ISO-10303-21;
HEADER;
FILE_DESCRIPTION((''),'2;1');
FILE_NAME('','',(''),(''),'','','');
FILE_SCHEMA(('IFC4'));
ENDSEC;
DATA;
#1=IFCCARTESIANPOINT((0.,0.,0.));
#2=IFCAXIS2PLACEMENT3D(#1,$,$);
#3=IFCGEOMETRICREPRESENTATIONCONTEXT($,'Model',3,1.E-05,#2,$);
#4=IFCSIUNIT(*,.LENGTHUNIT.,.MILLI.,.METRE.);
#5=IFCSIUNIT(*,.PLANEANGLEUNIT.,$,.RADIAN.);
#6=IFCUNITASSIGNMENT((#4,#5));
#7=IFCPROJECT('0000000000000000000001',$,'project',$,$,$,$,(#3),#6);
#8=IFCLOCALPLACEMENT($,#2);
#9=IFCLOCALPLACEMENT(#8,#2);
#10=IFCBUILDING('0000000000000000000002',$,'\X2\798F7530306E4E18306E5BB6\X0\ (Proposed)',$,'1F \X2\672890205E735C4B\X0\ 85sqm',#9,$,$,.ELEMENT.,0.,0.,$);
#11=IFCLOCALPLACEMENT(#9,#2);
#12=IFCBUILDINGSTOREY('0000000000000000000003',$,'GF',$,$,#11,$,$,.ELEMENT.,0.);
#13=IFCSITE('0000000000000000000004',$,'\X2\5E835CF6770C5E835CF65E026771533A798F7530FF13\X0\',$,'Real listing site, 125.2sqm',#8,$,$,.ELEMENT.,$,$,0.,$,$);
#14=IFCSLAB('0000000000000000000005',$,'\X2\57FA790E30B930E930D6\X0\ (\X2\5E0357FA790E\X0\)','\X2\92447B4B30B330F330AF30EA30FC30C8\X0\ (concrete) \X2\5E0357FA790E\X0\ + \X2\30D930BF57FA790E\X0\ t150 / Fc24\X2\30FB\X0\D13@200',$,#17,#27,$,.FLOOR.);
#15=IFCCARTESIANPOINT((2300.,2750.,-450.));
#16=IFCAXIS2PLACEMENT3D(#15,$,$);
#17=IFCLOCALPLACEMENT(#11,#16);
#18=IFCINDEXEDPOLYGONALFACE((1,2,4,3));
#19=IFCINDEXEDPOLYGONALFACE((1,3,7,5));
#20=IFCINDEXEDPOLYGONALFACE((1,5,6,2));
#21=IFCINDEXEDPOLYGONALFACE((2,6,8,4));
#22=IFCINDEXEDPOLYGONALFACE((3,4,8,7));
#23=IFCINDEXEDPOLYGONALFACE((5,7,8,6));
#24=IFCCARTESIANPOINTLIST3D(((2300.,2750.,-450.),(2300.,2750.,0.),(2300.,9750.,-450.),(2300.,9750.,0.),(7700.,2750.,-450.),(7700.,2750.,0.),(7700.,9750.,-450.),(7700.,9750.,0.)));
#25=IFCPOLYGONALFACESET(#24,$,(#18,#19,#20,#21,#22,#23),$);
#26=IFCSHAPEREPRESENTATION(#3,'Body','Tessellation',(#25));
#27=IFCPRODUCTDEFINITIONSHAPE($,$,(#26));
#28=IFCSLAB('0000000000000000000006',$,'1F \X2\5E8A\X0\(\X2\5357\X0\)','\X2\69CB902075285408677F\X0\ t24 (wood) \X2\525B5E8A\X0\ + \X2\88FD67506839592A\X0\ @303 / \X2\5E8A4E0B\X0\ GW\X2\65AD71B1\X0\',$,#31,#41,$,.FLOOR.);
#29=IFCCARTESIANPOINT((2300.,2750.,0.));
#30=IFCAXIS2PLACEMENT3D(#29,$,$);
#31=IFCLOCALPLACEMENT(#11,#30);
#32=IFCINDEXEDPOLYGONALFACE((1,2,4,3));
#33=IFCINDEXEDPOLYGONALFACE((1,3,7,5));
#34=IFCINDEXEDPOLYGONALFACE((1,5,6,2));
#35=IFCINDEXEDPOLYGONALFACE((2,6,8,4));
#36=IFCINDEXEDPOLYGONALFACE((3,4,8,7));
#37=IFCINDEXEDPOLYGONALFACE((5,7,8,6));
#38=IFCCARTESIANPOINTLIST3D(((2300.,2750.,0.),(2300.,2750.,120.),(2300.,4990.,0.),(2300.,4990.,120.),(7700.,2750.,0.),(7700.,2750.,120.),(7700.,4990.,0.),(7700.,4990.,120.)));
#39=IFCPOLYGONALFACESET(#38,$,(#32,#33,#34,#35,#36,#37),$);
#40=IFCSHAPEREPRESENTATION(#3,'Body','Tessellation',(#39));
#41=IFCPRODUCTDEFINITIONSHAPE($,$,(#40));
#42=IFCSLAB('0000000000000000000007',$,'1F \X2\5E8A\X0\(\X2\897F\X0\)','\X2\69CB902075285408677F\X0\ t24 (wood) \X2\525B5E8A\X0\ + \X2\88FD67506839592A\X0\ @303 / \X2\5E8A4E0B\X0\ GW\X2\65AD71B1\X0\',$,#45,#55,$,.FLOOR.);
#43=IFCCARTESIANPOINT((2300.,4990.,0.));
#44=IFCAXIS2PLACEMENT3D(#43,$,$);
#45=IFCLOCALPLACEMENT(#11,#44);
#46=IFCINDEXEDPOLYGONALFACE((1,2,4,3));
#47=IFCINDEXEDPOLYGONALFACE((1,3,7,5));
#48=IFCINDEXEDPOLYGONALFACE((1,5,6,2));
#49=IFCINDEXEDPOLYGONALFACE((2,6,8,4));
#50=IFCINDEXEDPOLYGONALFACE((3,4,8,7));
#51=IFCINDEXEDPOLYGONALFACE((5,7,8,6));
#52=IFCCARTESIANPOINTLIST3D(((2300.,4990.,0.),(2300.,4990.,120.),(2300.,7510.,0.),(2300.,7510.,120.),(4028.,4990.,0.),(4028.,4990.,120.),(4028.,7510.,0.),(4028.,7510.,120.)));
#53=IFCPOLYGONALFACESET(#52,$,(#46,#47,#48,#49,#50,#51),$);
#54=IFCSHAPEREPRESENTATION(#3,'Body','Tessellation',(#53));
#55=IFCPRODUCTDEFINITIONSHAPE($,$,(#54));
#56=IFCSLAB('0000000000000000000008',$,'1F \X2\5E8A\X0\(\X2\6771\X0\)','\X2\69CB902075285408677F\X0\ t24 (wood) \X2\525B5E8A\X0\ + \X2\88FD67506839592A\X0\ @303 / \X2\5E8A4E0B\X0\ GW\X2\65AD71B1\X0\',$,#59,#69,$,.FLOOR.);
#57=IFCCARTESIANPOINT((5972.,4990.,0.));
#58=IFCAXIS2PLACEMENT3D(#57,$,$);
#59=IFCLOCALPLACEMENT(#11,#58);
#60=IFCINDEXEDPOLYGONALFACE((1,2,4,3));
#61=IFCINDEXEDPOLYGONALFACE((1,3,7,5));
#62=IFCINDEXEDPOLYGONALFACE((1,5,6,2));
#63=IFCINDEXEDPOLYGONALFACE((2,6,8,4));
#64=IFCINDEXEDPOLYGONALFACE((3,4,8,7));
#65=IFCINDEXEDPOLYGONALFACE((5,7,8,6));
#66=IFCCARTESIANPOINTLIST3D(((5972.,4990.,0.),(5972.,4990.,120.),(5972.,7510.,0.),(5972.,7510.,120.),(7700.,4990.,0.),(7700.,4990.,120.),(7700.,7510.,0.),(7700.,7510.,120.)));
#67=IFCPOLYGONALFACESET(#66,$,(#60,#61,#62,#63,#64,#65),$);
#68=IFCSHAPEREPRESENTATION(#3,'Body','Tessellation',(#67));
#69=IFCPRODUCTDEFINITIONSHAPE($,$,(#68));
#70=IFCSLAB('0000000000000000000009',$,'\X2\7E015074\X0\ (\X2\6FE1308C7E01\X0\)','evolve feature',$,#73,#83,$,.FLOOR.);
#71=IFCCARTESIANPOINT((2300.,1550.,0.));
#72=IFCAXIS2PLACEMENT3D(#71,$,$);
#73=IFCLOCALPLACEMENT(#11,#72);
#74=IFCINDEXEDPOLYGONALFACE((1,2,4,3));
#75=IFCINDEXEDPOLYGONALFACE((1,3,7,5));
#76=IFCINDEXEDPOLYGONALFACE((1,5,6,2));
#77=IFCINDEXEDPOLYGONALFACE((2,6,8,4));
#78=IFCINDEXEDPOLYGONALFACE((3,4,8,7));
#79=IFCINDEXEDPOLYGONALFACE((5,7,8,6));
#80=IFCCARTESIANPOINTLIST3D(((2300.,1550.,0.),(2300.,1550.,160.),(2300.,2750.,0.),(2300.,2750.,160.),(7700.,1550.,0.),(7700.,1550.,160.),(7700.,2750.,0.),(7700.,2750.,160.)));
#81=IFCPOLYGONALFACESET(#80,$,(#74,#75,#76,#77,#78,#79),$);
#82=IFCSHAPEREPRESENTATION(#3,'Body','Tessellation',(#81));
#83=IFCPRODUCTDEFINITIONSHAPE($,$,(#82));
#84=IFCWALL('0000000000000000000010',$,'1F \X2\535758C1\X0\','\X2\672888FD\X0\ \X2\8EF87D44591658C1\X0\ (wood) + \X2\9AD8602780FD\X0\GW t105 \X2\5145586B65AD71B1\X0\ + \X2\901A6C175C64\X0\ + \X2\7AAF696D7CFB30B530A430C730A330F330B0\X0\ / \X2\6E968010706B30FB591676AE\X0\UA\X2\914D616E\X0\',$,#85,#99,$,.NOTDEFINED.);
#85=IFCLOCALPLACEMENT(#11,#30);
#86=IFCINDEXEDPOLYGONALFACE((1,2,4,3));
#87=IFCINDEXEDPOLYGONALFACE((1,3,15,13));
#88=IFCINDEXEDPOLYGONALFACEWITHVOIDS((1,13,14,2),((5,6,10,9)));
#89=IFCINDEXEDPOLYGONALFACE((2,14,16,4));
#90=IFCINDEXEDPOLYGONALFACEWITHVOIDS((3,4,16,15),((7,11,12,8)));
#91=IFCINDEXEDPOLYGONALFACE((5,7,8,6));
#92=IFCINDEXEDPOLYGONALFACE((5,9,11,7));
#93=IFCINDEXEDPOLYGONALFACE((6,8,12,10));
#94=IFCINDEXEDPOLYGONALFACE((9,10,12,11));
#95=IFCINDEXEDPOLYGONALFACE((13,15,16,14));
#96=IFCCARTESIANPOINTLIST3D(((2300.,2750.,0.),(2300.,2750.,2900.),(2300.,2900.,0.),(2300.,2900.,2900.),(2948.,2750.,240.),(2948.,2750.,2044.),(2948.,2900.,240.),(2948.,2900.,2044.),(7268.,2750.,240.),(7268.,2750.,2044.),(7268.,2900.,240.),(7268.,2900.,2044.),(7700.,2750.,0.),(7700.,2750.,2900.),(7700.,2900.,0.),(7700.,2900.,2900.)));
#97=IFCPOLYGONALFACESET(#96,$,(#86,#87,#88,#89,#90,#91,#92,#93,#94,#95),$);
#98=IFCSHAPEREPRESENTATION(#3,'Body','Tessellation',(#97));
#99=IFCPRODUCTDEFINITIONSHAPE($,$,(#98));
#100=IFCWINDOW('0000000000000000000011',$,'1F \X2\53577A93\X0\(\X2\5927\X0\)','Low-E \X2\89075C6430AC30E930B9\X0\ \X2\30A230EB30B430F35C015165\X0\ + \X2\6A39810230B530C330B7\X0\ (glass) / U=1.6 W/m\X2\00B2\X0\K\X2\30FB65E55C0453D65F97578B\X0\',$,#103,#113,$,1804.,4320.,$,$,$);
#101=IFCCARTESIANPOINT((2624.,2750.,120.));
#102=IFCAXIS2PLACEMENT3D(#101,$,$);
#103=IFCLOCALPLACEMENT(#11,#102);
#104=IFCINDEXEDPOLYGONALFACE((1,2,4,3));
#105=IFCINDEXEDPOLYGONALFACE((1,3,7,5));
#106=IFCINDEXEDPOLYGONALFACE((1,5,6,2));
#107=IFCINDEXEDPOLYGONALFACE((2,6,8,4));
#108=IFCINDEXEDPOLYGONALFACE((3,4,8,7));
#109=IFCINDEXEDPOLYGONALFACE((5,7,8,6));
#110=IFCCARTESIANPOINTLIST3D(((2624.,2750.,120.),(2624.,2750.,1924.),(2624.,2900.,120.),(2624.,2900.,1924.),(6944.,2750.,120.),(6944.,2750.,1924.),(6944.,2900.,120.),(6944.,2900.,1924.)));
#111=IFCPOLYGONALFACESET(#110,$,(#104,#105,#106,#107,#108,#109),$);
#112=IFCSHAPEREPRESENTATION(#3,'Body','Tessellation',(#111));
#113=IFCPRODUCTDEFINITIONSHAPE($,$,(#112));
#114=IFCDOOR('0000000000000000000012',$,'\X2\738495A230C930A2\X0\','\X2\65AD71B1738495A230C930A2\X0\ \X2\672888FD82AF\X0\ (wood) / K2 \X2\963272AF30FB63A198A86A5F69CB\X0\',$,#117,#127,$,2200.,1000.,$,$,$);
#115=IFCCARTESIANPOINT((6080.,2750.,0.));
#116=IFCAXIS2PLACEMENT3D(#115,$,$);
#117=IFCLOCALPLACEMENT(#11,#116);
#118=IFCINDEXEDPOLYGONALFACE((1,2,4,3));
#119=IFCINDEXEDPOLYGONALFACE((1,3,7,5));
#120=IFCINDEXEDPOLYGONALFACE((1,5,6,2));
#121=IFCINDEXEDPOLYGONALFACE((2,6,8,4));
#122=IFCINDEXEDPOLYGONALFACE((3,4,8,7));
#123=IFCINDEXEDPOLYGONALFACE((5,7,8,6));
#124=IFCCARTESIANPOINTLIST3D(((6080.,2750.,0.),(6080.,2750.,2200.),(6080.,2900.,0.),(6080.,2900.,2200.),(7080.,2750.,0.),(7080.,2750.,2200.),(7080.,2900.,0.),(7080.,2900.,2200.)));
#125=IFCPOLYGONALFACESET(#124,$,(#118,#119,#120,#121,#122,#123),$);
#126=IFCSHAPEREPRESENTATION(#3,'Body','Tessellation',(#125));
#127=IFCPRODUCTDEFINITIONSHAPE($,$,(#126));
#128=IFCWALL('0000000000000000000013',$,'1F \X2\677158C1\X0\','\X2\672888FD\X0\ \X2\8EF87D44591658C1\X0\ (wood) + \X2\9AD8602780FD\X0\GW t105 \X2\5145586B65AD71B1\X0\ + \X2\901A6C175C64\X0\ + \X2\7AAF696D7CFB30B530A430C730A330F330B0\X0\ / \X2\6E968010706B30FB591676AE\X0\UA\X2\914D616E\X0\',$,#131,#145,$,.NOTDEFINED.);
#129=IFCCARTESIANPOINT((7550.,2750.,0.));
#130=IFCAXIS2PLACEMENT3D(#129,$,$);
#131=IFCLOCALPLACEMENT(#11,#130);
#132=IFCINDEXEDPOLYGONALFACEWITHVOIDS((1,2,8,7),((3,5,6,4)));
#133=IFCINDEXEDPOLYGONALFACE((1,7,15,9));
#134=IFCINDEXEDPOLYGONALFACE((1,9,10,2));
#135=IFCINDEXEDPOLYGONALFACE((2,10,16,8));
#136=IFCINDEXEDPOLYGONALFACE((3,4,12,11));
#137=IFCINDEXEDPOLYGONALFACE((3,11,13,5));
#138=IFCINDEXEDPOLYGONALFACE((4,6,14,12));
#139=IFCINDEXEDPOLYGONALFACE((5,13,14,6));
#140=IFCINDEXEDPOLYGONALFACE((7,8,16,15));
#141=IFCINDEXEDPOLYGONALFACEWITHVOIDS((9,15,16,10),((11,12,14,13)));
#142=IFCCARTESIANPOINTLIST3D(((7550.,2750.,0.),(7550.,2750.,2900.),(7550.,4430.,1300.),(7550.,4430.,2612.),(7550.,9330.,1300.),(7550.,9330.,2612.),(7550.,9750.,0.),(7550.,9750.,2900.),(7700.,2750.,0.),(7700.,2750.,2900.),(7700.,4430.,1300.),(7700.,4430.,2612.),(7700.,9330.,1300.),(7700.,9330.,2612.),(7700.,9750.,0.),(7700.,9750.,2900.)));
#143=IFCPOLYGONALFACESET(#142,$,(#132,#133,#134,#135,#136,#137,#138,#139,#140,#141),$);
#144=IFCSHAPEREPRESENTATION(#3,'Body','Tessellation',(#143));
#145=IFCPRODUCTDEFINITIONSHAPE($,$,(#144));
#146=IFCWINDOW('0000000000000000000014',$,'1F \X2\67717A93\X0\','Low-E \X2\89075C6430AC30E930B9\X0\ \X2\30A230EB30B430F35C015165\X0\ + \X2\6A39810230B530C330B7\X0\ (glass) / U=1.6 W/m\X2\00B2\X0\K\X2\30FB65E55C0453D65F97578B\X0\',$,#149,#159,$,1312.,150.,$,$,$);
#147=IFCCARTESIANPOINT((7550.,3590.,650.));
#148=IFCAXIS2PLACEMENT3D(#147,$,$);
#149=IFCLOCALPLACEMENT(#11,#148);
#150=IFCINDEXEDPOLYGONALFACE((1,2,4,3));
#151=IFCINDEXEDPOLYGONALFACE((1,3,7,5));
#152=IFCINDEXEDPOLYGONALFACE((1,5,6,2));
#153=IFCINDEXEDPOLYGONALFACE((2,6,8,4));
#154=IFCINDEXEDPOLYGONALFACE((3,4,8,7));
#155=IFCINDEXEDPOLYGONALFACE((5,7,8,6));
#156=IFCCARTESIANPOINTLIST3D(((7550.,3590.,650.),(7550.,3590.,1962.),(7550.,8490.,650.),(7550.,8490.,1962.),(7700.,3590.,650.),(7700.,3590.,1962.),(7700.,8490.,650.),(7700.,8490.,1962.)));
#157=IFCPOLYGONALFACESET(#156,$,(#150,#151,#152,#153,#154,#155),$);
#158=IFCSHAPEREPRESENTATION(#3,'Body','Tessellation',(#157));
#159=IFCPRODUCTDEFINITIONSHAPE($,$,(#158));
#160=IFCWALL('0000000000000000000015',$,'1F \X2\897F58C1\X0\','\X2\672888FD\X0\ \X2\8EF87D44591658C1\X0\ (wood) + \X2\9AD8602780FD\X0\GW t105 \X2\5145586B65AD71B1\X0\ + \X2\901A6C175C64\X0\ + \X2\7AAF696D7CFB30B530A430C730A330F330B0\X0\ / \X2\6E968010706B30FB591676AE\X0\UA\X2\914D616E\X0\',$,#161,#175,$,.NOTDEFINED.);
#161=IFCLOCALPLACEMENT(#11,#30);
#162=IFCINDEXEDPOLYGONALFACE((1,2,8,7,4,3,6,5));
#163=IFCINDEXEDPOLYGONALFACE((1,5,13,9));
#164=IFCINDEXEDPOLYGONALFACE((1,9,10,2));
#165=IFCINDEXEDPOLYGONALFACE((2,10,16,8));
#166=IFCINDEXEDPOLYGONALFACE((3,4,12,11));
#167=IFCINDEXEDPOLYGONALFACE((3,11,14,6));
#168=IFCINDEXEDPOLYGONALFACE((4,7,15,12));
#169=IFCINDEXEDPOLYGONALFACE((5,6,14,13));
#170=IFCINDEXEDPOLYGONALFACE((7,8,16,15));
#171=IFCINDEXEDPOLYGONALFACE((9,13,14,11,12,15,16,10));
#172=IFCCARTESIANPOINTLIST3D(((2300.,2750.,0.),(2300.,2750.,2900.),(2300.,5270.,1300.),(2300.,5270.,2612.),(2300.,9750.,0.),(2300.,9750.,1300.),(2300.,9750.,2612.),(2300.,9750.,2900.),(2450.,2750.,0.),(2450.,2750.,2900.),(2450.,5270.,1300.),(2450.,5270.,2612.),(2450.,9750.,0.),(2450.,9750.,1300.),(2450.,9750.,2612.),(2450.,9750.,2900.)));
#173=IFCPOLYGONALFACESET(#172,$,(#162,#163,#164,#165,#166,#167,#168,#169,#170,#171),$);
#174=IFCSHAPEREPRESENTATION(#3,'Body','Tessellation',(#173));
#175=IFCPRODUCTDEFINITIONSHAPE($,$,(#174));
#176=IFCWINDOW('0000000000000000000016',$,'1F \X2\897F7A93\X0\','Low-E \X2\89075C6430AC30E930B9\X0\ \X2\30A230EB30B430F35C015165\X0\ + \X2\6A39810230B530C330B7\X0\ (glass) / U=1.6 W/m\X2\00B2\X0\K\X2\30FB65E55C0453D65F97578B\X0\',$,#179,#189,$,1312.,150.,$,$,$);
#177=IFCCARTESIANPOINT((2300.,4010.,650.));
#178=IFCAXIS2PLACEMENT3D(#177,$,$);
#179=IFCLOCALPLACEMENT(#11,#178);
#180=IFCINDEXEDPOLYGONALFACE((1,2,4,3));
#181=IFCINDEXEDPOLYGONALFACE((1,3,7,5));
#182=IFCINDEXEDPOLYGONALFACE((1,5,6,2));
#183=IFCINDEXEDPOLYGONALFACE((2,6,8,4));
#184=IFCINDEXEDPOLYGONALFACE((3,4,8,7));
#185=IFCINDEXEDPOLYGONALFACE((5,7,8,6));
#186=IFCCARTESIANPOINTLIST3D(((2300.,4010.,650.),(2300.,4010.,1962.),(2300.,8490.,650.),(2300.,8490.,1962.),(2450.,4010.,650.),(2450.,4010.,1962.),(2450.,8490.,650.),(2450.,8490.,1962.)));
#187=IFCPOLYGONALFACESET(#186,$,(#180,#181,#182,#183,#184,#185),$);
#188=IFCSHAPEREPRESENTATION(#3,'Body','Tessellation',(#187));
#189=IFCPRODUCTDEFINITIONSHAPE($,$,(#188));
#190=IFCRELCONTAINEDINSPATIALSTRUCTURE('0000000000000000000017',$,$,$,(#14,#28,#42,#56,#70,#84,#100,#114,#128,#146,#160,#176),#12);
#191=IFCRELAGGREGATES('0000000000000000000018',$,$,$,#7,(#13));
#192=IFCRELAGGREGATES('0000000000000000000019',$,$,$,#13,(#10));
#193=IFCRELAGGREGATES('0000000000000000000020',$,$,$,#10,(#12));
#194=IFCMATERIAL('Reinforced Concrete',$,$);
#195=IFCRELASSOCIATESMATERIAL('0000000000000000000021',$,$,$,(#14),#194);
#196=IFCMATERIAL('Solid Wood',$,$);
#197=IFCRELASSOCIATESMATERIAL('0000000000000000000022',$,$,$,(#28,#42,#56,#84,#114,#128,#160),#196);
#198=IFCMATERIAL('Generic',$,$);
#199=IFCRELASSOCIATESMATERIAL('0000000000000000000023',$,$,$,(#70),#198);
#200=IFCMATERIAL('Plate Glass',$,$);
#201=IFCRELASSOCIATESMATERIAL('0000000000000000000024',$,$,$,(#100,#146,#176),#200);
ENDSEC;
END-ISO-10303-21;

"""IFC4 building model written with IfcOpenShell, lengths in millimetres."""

from ifc_helpers import new_model, si_unit, frame, frame_2d, origin, place, context, project, spatial, rectangle, extrude, material, element, fill, save


model = new_model("IFC4")

# Units and contexts
model_context = context("Model", 3, precision=1e-05, world=origin())
ifc_project = project(units=[si_unit("LENGTHUNIT", "METRE", prefix="MILLI"), si_unit("PLANEANGLEUNIT", "RADIAN")], contexts=[model_context])

# Site, building, storey
site_placement = place(None, origin())
site = spatial("IfcSite", under=ifc_project, at=site_placement, Name="広島県広島市東区福田３", ObjectType="Real listing site, 125.2sqm", CompositionType="ELEMENT", RefElevation=0.0)
building_placement = place(site_placement, origin())
building = spatial("IfcBuilding", under=site, at=building_placement, Name="福田の丘の家 (Proposed)", ObjectType="1F 木造平屋 85sqm", CompositionType="ELEMENT", ElevationOfRefHeight=0.0, ElevationOfTerrain=0.0)
storey_placement = place(building_placement, origin())
storey = spatial("IfcBuildingStorey", under=building, at=storey_placement, Name="GF", CompositionType="ELEMENT", Elevation=0.0)

# Slabs
ifc_material_1 = material(Name="Reinforced Concrete")
slab_1_placement = place(storey_placement, frame((2300.0, 2750.0, -450.0)))
element("IfcSlab", 1, at=slab_1_placement, inside=storey, material=ifc_material_1, Name="基礎スラブ (布基礎)", Description="鉄筋コンクリート (concrete) 布基礎 + ベタ基礎 t150 / Fc24・D13@200", PredefinedType="FLOOR", context=model_context, shape_type="SweptSolid", body=[
    extrude(rectangle(XDim=5400.0, YDim=7000.0, at=frame_2d((2700.0, 3500.0))), frame((2300.0, 2750.0, -450.0)), (0.0, 0.0, 1.0), 450.0),
])
ifc_material_2 = material(Name="Solid Wood")
slab_2_placement = place(storey_placement, frame((2300.0, 2750.0, 0.0)))
element("IfcSlab", 2, at=slab_2_placement, inside=storey, material=ifc_material_2, Name="1F 床(南)", Description="構造用合板 t24 (wood) 剛床 + 製材根太 @303 / 床下 GW断熱", PredefinedType="FLOOR", context=model_context, shape_type="SweptSolid", body=[
    extrude(rectangle(XDim=5400.0, YDim=2240.0, at=frame_2d((2700.0, 1120.0))), frame((2300.0, 2750.0, 0.0)), (0.0, 0.0, 1.0), 120.0),
])
slab_3_placement = place(storey_placement, frame((2300.0, 4990.0, 0.0)))
element("IfcSlab", 3, at=slab_3_placement, inside=storey, material=ifc_material_2, Name="1F 床(西)", Description="構造用合板 t24 (wood) 剛床 + 製材根太 @303 / 床下 GW断熱", PredefinedType="FLOOR", context=model_context, shape_type="SweptSolid", body=[
    extrude(rectangle(XDim=1728.0, YDim=2520.0, at=frame_2d((864.0, 1260.0))), frame((2300.0, 4990.0, 0.0)), (0.0, 0.0, 1.0), 120.0),
])
slab_4_placement = place(storey_placement, frame((5972.0, 4990.0, 0.0)))
element("IfcSlab", 4, at=slab_4_placement, inside=storey, material=ifc_material_2, Name="1F 床(東)", Description="構造用合板 t24 (wood) 剛床 + 製材根太 @303 / 床下 GW断熱", PredefinedType="FLOOR", context=model_context, shape_type="SweptSolid", body=[
    extrude(rectangle(XDim=1728.0, YDim=2520.0, at=frame_2d((864.0, 1260.0))), frame((5972.0, 4990.0, 0.0)), (0.0, 0.0, 1.0), 120.0),
])
ifc_material_3 = material(Name="Generic")
slab_5_placement = place(storey_placement, frame((2300.0, 1550.0, 0.0)))
element("IfcSlab", 5, at=slab_5_placement, inside=storey, material=ifc_material_3, Name="縁側 (濡れ縁)", Description="evolve feature", PredefinedType="FLOOR", context=model_context, shape_type="SweptSolid", body=[
    extrude(rectangle(XDim=5400.0, YDim=1200.0, at=frame_2d((2700.0, 600.0))), frame((2300.0, 1550.0, 0.0)), (0.0, 0.0, 1.0), 160.0),
])

# Wall, openings, window, door
wall_1_placement = place(storey_placement, frame((2300.0, 2750.0, 0.0)))
wall_1 = element("IfcWall", 6, at=wall_1_placement, inside=storey, material=ifc_material_2, Name="1F 南壁", Description="木製 軸組外壁 (wood) + 高性能GW t105 充填断熱 + 通気層 + 窯業系サイディング / 準耐火・外皮UA配慮", PredefinedType="NOTDEFINED", context=model_context, shape_type="SweptSolid", body=[
    extrude(rectangle(XDim=5400.0, YDim=150.0, at=frame_2d((2700.0, 75.0))), frame((2300.0, 2750.0, 0.0)), (0.0, 0.0, 1.0), 2900.0),
])
opening_1_placement = place(storey_placement, frame((2624.0, 2750.0, 120.0)))
opening_1 = element("IfcOpeningElement", 7, at=opening_1_placement, cuts=wall_1, PredefinedType="NOTDEFINED", context=model_context, shape_type="SweptSolid", body=[
    extrude(rectangle(XDim=4320.0, YDim=150.0, at=frame_2d((2160.0, 75.0))), frame((2624.0, 2750.0, 120.0)), (0.0, 0.0, 1.0), 1804.0),
])
opening_2_placement = place(storey_placement, frame((6080.0, 2750.0, 0.0)))
opening_2 = element("IfcOpeningElement", 8, at=opening_2_placement, cuts=wall_1, PredefinedType="NOTDEFINED", context=model_context, shape_type="SweptSolid", body=[
    extrude(rectangle(XDim=1000.0, YDim=150.0, at=frame_2d((500.0, 75.0))), frame((6080.0, 2750.0, 0.0)), (0.0, 0.0, 1.0), 2200.0),
])
ifc_material_4 = material(Name="Plate Glass")
window_1_placement = place(storey_placement, frame((2624.0, 2750.0, 120.0)))
window_1 = element("IfcWindow", 9, at=window_1_placement, inside=storey, material=ifc_material_4, Name="1F 南窓(大)", Description="Low-E 複層ガラス アルゴン封入 + 樹脂サッシ (glass) / U=1.6 W/m²K・日射取得型", OverallHeight=1804.0, OverallWidth=4320.0, context=model_context, shape_type="SweptSolid", body=[
    extrude(rectangle(XDim=4320.0, YDim=150.0, at=frame_2d((2160.0, 75.0))), frame((2624.0, 2750.0, 120.0)), (0.0, 0.0, 1.0), 1804.0),
])
fill(opening_1, window_1)
door_placement = place(storey_placement, frame((6080.0, 2750.0, 0.0)))
door = element("IfcDoor", 10, at=door_placement, inside=storey, material=ifc_material_2, Name="玄関ドア", Description="断熱玄関ドア 木製芯 (wood) / K2 防犯・採風機構", OverallHeight=2200.0, OverallWidth=1000.0, context=model_context, shape_type="SweptSolid", body=[
    extrude(rectangle(XDim=1000.0, YDim=150.0, at=frame_2d((500.0, 75.0))), frame((6080.0, 2750.0, 0.0)), (0.0, 0.0, 1.0), 2200.0),
])
fill(opening_2, door)

# Walls, openings, windows
wall_2_placement = place(storey_placement, frame((7550.0, 2750.0, 0.0)))
wall_2 = element("IfcWall", 11, at=wall_2_placement, inside=storey, material=ifc_material_2, Name="1F 東壁", Description="木製 軸組外壁 (wood) + 高性能GW t105 充填断熱 + 通気層 + 窯業系サイディング / 準耐火・外皮UA配慮", PredefinedType="NOTDEFINED", context=model_context, shape_type="SweptSolid", body=[
    extrude(rectangle(XDim=150.0, YDim=7000.0, at=frame_2d((75.0, 3500.0))), frame((7550.0, 2750.0, 0.0)), (0.0, 0.0, 1.0), 2900.0),
])
opening_3_placement = place(storey_placement, frame((7550.0, 3590.0, 650.0)))
opening_3 = element("IfcOpeningElement", 12, at=opening_3_placement, cuts=wall_2, PredefinedType="NOTDEFINED", context=model_context, shape_type="SweptSolid", body=[
    extrude(rectangle(XDim=150.0, YDim=4900.0, at=frame_2d((75.0, 2450.0))), frame((7550.0, 3590.0, 650.0)), (0.0, 0.0, 1.0), 1312.0),
])
window_2_placement = place(storey_placement, frame((7550.0, 3590.0, 650.0)))
window_2 = element("IfcWindow", 13, at=window_2_placement, inside=storey, material=ifc_material_4, Name="1F 東窓", Description="Low-E 複層ガラス アルゴン封入 + 樹脂サッシ (glass) / U=1.6 W/m²K・日射取得型", OverallHeight=1312.0, OverallWidth=150.0, context=model_context, shape_type="SweptSolid", body=[
    extrude(rectangle(XDim=150.0, YDim=4900.0, at=frame_2d((75.0, 2450.0))), frame((7550.0, 3590.0, 650.0)), (0.0, 0.0, 1.0), 1312.0),
])
fill(opening_3, window_2)
wall_3_placement = place(storey_placement, frame((2300.0, 2750.0, 0.0)))
wall_3 = element("IfcWall", 14, at=wall_3_placement, inside=storey, material=ifc_material_2, Name="1F 西壁", Description="木製 軸組外壁 (wood) + 高性能GW t105 充填断熱 + 通気層 + 窯業系サイディング / 準耐火・外皮UA配慮", PredefinedType="NOTDEFINED", context=model_context, shape_type="SweptSolid", body=[
    extrude(rectangle(XDim=150.0, YDim=7000.0, at=frame_2d((75.0, 3500.0))), frame((2300.0, 2750.0, 0.0)), (0.0, 0.0, 1.0), 2900.0),
])
opening_4_placement = place(storey_placement, frame((2300.0, 4010.0, 650.0)))
opening_4 = element("IfcOpeningElement", 15, at=opening_4_placement, cuts=wall_3, PredefinedType="NOTDEFINED", context=model_context, shape_type="SweptSolid", body=[
    extrude(rectangle(XDim=150.0, YDim=4480.0, at=frame_2d((75.0, 2240.0))), frame((2300.0, 4010.0, 650.0)), (0.0, 0.0, 1.0), 1312.0),
])
window_3_placement = place(storey_placement, frame((2300.0, 4010.0, 650.0)))
window_3 = element("IfcWindow", 16, at=window_3_placement, inside=storey, material=ifc_material_4, Name="1F 西窓", Description="Low-E 複層ガラス アルゴン封入 + 樹脂サッシ (glass) / U=1.6 W/m²K・日射取得型", OverallHeight=1312.0, OverallWidth=150.0, context=model_context, shape_type="SweptSolid", body=[
    extrude(rectangle(XDim=150.0, YDim=4480.0, at=frame_2d((75.0, 2240.0))), frame((2300.0, 4010.0, 650.0)), (0.0, 0.0, 1.0), 1312.0),
])
fill(opening_4, window_3)

save(model, "model.ifc")
